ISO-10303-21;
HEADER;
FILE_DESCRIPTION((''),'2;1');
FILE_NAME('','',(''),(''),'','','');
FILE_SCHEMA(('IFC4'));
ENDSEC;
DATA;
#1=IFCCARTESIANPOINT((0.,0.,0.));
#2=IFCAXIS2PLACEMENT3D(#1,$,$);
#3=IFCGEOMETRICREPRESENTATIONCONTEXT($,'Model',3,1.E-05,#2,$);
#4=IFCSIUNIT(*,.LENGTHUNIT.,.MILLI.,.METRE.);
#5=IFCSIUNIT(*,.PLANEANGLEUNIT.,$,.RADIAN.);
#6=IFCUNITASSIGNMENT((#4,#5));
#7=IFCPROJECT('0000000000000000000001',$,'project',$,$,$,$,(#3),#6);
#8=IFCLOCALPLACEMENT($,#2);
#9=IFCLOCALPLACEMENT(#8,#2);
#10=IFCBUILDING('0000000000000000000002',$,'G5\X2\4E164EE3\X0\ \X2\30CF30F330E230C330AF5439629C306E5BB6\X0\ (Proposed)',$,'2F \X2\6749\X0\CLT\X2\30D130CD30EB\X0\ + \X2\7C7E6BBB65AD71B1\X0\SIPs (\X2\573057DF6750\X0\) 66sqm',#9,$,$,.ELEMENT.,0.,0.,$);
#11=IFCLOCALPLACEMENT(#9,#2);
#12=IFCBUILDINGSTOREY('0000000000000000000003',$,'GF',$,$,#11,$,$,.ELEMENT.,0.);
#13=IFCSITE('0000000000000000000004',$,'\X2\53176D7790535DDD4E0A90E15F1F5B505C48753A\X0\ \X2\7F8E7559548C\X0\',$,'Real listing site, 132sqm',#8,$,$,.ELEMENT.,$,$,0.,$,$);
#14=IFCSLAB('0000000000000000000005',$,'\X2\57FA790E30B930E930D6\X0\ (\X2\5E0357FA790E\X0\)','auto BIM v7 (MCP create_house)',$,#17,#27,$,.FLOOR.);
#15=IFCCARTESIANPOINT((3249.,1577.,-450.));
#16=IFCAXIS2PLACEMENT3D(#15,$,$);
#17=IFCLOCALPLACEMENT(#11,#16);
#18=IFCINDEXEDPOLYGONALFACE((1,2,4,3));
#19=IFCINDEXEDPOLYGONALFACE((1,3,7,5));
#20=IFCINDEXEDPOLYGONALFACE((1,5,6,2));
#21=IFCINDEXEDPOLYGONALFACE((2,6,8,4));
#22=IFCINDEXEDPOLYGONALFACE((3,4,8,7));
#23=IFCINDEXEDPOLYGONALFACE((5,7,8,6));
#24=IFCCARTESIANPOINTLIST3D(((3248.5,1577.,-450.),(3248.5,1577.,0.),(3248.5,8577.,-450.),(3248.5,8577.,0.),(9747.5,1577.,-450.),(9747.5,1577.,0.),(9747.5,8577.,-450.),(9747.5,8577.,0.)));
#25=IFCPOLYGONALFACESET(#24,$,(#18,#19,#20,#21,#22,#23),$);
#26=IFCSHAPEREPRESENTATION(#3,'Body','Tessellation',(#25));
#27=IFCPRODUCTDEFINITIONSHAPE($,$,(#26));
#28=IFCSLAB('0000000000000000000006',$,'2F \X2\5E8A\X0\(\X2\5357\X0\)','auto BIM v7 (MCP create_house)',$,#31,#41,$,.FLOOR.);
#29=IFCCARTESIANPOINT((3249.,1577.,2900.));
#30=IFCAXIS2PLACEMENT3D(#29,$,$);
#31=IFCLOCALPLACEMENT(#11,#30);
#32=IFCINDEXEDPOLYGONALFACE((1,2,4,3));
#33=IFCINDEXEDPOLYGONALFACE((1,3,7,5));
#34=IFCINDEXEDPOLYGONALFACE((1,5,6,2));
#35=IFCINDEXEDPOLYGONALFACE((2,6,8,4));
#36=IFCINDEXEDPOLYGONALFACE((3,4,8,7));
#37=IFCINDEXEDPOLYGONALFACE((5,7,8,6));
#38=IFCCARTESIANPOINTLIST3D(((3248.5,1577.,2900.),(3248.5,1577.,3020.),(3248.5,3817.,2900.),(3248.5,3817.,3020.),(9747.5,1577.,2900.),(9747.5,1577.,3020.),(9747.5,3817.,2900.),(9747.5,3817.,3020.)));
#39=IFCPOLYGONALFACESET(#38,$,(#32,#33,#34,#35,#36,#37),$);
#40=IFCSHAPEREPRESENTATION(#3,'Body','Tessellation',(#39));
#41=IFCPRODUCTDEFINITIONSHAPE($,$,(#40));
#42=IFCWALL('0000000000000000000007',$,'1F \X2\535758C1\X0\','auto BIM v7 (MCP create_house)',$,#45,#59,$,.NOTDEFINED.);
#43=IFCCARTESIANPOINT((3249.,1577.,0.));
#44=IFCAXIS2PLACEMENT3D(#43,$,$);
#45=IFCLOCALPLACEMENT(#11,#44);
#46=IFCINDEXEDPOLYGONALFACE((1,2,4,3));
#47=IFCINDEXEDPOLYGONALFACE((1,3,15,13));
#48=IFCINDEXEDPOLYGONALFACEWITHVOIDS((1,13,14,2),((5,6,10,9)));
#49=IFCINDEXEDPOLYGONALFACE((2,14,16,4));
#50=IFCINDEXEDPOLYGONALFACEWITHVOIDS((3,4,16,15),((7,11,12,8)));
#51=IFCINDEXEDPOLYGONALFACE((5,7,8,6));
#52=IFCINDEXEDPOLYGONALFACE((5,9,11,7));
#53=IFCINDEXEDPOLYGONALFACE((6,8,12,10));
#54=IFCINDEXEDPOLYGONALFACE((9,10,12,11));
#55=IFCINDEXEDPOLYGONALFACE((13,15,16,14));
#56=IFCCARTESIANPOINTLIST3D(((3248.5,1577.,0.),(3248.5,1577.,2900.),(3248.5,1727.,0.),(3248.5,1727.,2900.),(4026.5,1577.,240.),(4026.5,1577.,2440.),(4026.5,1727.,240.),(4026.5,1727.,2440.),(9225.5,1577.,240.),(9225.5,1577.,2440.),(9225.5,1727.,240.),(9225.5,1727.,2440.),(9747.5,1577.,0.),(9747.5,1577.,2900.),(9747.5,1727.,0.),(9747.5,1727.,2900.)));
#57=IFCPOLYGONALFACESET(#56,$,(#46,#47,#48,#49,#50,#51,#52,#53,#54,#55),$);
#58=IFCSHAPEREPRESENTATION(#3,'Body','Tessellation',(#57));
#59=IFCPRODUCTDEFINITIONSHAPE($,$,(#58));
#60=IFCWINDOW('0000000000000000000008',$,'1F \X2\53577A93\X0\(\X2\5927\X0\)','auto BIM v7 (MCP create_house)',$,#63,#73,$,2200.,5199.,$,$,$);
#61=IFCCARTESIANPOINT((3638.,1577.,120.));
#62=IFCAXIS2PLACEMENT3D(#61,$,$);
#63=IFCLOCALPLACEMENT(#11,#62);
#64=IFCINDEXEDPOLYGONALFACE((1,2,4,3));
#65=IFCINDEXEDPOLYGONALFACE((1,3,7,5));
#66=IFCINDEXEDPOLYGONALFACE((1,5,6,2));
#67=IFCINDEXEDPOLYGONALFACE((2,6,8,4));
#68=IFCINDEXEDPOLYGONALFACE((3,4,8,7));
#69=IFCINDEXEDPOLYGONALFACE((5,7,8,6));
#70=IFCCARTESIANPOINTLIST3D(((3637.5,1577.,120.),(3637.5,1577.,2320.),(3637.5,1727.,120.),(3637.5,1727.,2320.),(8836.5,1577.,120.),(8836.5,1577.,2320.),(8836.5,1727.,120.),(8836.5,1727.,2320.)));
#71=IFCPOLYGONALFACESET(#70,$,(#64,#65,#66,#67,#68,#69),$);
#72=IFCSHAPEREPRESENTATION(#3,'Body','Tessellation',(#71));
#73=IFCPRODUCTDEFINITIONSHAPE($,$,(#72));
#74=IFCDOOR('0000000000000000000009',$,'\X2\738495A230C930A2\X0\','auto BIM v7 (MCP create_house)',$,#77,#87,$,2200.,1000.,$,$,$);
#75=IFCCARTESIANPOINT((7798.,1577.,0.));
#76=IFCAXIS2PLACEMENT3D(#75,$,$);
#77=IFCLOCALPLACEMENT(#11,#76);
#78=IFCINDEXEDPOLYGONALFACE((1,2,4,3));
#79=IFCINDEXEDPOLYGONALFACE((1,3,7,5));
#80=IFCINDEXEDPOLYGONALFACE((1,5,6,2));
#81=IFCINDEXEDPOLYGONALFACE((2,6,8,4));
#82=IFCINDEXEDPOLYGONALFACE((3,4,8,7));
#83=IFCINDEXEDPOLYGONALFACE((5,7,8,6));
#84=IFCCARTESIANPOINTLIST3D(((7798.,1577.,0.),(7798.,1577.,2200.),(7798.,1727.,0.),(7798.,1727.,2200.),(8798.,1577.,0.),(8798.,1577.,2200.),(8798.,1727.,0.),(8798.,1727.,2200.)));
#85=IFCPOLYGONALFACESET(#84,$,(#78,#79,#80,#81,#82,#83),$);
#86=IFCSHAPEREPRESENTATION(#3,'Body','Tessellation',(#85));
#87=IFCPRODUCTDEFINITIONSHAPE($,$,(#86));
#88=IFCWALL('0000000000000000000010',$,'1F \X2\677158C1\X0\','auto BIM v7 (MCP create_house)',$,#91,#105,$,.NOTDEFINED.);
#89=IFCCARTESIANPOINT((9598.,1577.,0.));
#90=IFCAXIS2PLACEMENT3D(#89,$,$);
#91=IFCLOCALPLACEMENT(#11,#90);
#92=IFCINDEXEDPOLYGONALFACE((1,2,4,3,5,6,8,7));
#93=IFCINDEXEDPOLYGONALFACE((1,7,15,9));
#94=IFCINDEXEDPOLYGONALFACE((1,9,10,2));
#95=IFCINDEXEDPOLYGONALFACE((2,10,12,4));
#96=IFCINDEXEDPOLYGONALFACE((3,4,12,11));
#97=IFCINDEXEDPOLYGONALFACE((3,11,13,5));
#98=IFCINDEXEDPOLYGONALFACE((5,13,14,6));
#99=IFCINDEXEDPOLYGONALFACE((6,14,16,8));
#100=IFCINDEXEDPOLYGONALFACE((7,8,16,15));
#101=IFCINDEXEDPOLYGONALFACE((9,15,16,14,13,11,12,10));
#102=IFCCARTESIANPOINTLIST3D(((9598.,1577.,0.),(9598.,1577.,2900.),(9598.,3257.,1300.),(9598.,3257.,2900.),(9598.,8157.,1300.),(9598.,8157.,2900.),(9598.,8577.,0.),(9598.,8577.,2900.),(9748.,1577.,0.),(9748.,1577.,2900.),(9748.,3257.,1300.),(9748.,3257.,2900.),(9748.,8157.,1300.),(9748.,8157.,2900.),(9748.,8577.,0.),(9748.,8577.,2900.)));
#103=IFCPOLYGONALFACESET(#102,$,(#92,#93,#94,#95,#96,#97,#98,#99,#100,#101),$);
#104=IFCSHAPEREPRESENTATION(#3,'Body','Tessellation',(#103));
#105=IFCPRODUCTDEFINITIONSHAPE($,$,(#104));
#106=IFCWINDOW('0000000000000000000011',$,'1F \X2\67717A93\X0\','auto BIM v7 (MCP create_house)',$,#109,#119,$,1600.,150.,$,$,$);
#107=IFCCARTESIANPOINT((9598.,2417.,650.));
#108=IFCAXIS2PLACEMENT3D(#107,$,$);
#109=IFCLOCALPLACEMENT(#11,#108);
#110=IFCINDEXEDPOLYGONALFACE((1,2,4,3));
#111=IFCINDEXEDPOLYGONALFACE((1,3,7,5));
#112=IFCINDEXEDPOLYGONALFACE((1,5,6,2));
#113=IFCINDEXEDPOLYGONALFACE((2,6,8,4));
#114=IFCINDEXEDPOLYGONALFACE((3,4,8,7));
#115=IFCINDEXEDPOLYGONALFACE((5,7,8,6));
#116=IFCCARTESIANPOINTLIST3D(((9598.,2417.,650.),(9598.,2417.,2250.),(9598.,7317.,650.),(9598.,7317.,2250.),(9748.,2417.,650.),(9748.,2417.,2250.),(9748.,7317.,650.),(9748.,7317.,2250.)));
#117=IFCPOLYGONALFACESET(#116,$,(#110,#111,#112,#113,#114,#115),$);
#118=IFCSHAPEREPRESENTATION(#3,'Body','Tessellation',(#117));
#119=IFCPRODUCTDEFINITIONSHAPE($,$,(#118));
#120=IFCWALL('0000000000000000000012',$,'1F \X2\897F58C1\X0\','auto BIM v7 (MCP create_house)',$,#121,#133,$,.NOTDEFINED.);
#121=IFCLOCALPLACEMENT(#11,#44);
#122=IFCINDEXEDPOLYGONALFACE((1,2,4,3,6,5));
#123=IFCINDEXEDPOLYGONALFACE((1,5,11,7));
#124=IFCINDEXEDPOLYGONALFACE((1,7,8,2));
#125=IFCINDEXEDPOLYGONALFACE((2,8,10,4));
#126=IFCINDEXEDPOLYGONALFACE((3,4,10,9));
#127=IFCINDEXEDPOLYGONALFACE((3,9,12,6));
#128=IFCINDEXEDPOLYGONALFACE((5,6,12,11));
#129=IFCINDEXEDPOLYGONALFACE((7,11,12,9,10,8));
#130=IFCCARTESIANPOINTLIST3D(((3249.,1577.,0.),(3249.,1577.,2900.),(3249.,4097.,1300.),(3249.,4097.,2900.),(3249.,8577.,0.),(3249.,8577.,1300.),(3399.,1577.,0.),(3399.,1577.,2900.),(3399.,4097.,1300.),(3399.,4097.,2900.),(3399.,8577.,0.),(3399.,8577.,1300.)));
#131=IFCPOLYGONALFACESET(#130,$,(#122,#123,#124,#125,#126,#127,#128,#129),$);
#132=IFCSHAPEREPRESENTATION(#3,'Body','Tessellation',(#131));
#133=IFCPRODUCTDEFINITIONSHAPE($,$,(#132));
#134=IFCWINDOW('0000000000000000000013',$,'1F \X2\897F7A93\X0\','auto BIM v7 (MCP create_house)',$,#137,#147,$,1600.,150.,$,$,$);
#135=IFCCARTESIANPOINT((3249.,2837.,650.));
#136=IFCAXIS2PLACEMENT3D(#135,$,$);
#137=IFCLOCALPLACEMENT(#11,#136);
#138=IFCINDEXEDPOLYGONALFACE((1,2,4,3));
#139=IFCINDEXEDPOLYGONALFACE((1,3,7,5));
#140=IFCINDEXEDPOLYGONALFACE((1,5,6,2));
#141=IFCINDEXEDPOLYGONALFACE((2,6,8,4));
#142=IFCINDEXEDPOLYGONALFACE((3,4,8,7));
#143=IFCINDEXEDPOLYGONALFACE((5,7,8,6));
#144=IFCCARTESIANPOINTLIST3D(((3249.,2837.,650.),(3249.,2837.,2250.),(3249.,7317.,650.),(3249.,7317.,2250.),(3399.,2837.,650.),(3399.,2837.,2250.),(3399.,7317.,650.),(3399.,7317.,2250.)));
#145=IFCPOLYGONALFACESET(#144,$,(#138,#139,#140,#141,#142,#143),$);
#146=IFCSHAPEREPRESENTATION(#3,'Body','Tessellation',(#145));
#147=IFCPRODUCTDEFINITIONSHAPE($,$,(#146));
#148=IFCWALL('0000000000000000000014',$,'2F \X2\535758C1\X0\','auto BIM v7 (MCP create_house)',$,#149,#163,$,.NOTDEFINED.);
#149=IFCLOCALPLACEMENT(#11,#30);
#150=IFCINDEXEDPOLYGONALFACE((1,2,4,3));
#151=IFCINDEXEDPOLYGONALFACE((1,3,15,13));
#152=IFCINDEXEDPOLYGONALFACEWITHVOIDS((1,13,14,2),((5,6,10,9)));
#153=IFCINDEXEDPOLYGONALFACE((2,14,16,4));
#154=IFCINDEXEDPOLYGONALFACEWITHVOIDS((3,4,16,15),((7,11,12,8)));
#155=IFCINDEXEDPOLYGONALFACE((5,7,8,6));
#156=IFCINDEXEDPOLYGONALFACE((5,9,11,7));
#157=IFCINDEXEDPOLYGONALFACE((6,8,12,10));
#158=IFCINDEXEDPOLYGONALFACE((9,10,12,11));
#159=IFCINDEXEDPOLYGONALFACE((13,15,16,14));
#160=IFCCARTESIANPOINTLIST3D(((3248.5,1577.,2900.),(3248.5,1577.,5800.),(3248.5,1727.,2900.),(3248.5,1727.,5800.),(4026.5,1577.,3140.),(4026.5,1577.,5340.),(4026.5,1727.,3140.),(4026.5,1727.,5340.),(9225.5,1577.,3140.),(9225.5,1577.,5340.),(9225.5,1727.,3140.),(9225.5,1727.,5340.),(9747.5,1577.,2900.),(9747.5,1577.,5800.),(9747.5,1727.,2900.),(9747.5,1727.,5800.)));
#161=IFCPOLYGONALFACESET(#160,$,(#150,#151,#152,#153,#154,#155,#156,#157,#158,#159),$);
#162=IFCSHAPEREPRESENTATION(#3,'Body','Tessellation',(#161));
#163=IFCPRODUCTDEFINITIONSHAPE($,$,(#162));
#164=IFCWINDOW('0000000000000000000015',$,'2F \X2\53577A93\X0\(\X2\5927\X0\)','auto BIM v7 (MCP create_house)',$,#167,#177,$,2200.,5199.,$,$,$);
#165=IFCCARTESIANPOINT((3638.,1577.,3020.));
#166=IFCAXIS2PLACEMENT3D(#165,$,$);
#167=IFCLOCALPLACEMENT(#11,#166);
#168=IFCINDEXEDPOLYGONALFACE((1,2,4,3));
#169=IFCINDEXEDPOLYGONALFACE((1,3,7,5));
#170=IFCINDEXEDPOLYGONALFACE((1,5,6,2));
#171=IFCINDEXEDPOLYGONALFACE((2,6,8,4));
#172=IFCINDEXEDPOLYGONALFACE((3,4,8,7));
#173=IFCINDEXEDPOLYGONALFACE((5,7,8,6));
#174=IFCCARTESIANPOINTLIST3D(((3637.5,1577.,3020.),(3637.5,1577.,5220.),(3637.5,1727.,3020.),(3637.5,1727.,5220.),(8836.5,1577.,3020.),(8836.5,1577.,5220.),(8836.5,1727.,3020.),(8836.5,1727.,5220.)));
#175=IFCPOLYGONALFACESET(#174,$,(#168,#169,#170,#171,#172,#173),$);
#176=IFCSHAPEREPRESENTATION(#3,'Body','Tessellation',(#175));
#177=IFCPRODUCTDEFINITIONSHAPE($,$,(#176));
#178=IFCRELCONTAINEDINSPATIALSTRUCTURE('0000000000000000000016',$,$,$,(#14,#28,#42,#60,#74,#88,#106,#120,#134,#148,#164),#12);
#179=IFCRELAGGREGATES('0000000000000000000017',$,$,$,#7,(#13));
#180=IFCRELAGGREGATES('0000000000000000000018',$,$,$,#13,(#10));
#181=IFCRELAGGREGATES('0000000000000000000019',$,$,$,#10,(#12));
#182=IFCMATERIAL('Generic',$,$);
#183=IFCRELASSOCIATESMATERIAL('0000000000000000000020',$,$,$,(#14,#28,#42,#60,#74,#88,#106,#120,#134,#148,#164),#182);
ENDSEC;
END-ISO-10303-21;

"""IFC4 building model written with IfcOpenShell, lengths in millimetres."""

from ifc_helpers import new_model, si_unit, frame, frame_2d, origin, place, context, project, spatial, rectangle, extrude, material, element, fill, save


model = new_model("IFC4")

# Units and contexts
model_context = context("Model", 3, precision=1e-05, world=origin())
ifc_project = project(units=[si_unit("LENGTHUNIT", "METRE", prefix="MILLI"), si_unit("PLANEANGLEUNIT", "RADIAN")], contexts=[model_context])

# Site, building, storey
site_placement = place(None, origin())
site = spatial("IfcSite", under=ifc_project, at=site_placement, Name="北海道川上郡弟子屈町 美留和", ObjectType="Real listing site, 132sqm", CompositionType="ELEMENT", RefElevation=0.0)
building_placement = place(site_placement, origin())
building = spatial("IfcBuilding", under=site, at=building_placement, Name="G5世代 ハンモック吹抜の家 (Proposed)", ObjectType="2F 杉CLTパネル + 籾殻断熱SIPs (地域材) 66sqm", CompositionType="ELEMENT", ElevationOfRefHeight=0.0, ElevationOfTerrain=0.0)
storey_placement = place(building_placement, origin())
storey = spatial("IfcBuildingStorey", under=building, at=storey_placement, Name="GF", CompositionType="ELEMENT", Elevation=0.0)

# Slabs
ifc_material = material(Name="Generic")
slab_1_placement = place(storey_placement, frame((3249.0, 1577.0, -450.0)))
element("IfcSlab", 1, at=slab_1_placement, inside=storey, material=ifc_material, Name="基礎スラブ (布基礎)", Description="auto BIM v7 (MCP create_house)", PredefinedType="FLOOR", context=model_context, shape_type="SweptSolid", body=[
    extrude(rectangle(XDim=6499.0, YDim=7000.0, at=frame_2d((3249.0, 3500.0))), frame((3249.0, 1577.0, -450.0)), (0.0, 0.0, 1.0), 450.0),
])
slab_2_placement = place(storey_placement, frame((3249.0, 1577.0, 2900.0)))
element("IfcSlab", 2, at=slab_2_placement, inside=storey, material=ifc_material, Name="2F 床(南)", Description="auto BIM v7 (MCP create_house)", PredefinedType="FLOOR", context=model_context, shape_type="SweptSolid", body=[
    extrude(rectangle(XDim=6499.0, YDim=2240.0, at=frame_2d((3249.0, 1120.0))), frame((3249.0, 1577.0, 2900.0)), (0.0, 0.0, 1.0), 120.0),
])

# Wall, openings, window, door
wall_1_placement = place(storey_placement, frame((3249.0, 1577.0, 0.0)))
wall_1 = element("IfcWall", 3, at=wall_1_placement, inside=storey, material=ifc_material, Name="1F 南壁", Description="auto BIM v7 (MCP create_house)", PredefinedType="NOTDEFINED", context=model_context, shape_type="SweptSolid", body=[
    extrude(rectangle(XDim=6499.0, YDim=150.0, at=frame_2d((3249.0, 75.0))), frame((3249.0, 1577.0, 0.0)), (0.0, 0.0, 1.0), 2900.0),
])
opening_1_placement = place(storey_placement, frame((3638.0, 1577.0, 120.0)))
opening_1 = element("IfcOpeningElement", 4, at=opening_1_placement, cuts=wall_1, PredefinedType="NOTDEFINED", context=model_context, shape_type="SweptSolid", body=[
    extrude(rectangle(XDim=5199.0, YDim=150.0, at=frame_2d((2599.0, 75.0))), frame((3638.0, 1577.0, 120.0)), (0.0, 0.0, 1.0), 2200.0),
])
opening_2_placement = place(storey_placement, frame((7798.0, 1577.0, 0.0)))
opening_2 = element("IfcOpeningElement", 5, at=opening_2_placement, cuts=wall_1, PredefinedType="NOTDEFINED", context=model_context, shape_type="SweptSolid", body=[
    extrude(rectangle(XDim=1000.0, YDim=150.0, at=frame_2d((500.0, 75.0))), frame((7798.0, 1577.0, 0.0)), (0.0, 0.0, 1.0), 2200.0),
])
window_1_placement = place(storey_placement, frame((3638.0, 1577.0, 120.0)))
window_1 = element("IfcWindow", 6, at=window_1_placement, inside=storey, material=ifc_material, Name="1F 南窓(大)", Description="auto BIM v7 (MCP create_house)", OverallHeight=2200.0, OverallWidth=5199.0, context=model_context, shape_type="SweptSolid", body=[
    extrude(rectangle(XDim=5199.0, YDim=150.0, at=frame_2d((2599.0, 75.0))), frame((3638.0, 1577.0, 120.0)), (0.0, 0.0, 1.0), 2200.0),
])
fill(opening_1, window_1)
door_placement = place(storey_placement, frame((7798.0, 1577.0, 0.0)))
door = element("IfcDoor", 7, at=door_placement, inside=storey, material=ifc_material, Name="玄関ドア", Description="auto BIM v7 (MCP create_house)", OverallHeight=2200.0, OverallWidth=1000.0, context=model_context, shape_type="SweptSolid", body=[
    extrude(rectangle(XDim=1000.0, YDim=150.0, at=frame_2d((500.0, 75.0))), frame((7798.0, 1577.0, 0.0)), (0.0, 0.0, 1.0), 2200.0),
])
fill(opening_2, door)

# Walls, openings, windows
wall_2_placement = place(storey_placement, frame((9598.0, 1577.0, 0.0)))
wall_2 = element("IfcWall", 8, at=wall_2_placement, inside=storey, material=ifc_material, Name="1F 東壁", Description="auto BIM v7 (MCP create_house)", PredefinedType="NOTDEFINED", context=model_context, shape_type="SweptSolid", body=[
    extrude(rectangle(XDim=150.0, YDim=7000.0, at=frame_2d((75.0, 3500.0))), frame((9598.0, 1577.0, 0.0)), (0.0, 0.0, 1.0), 2900.0),
])
opening_3_placement = place(storey_placement, frame((9598.0, 2417.0, 650.0)))
opening_3 = element("IfcOpeningElement", 9, at=opening_3_placement, cuts=wall_2, PredefinedType="NOTDEFINED", context=model_context, shape_type="SweptSolid", body=[
    extrude(rectangle(XDim=150.0, YDim=4900.0, at=frame_2d((75.0, 2450.0))), frame((9598.0, 2417.0, 650.0)), (0.0, 0.0, 1.0), 1600.0),
])
window_2_placement = place(storey_placement, frame((9598.0, 2417.0, 650.0)))
window_2 = element("IfcWindow", 10, at=window_2_placement, inside=storey, material=ifc_material, Name="1F 東窓", Description="auto BIM v7 (MCP create_house)", OverallHeight=1600.0, OverallWidth=150.0, context=model_context, shape_type="SweptSolid", body=[
    extrude(rectangle(XDim=150.0, YDim=4900.0, at=frame_2d((75.0, 2450.0))), frame((9598.0, 2417.0, 650.0)), (0.0, 0.0, 1.0), 1600.0),
])
fill(opening_3, window_2)
wall_3_placement = place(storey_placement, frame((3249.0, 1577.0, 0.0)))
wall_3 = element("IfcWall", 11, at=wall_3_placement, inside=storey, material=ifc_material, Name="1F 西壁", Description="auto BIM v7 (MCP create_house)", PredefinedType="NOTDEFINED", context=model_context, shape_type="SweptSolid", body=[
    extrude(rectangle(XDim=150.0, YDim=7000.0, at=frame_2d((75.0, 3500.0))), frame((3249.0, 1577.0, 0.0)), (0.0, 0.0, 1.0), 2900.0),
])
opening_4_placement = place(storey_placement, frame((3249.0, 2837.0, 650.0)))
opening_4 = element("IfcOpeningElement", 12, at=opening_4_placement, cuts=wall_3, PredefinedType="NOTDEFINED", context=model_context, shape_type="SweptSolid", body=[
    extrude(rectangle(XDim=150.0, YDim=4480.0, at=frame_2d((75.0, 2240.0))), frame((3249.0, 2837.0, 650.0)), (0.0, 0.0, 1.0), 1600.0),
])
window_3_placement = place(storey_placement, frame((3249.0, 2837.0, 650.0)))
window_3 = element("IfcWindow", 13, at=window_3_placement, inside=storey, material=ifc_material, Name="1F 西窓", Description="auto BIM v7 (MCP create_house)", OverallHeight=1600.0, OverallWidth=150.0, context=model_context, shape_type="SweptSolid", body=[
    extrude(rectangle(XDim=150.0, YDim=4480.0, at=frame_2d((75.0, 2240.0))), frame((3249.0, 2837.0, 650.0)), (0.0, 0.0, 1.0), 1600.0),
])
fill(opening_4, window_3)

# Wall, opening, window
wall_4_placement = place(storey_placement, frame((3249.0, 1577.0, 2900.0)))
wall_4 = element("IfcWall", 14, at=wall_4_placement, inside=storey, material=ifc_material, Name="2F 南壁", Description="auto BIM v7 (MCP create_house)", PredefinedType="NOTDEFINED", context=model_context, shape_type="SweptSolid", body=[
    extrude(rectangle(XDim=6499.0, YDim=150.0, at=frame_2d((3249.0, 75.0))), frame((3249.0, 1577.0, 2900.0)), (0.0, 0.0, 1.0), 2900.0),
])
opening_5_placement = place(storey_placement, frame((3638.0, 1577.0, 3020.0)))
opening_5 = element("IfcOpeningElement", 15, at=opening_5_placement, cuts=wall_4, PredefinedType="NOTDEFINED", context=model_context, shape_type="SweptSolid", body=[
    extrude(rectangle(XDim=5199.0, YDim=150.0, at=frame_2d((2599.0, 75.0))), frame((3638.0, 1577.0, 3020.0)), (0.0, 0.0, 1.0), 2200.0),
])
window_4_placement = place(storey_placement, frame((3638.0, 1577.0, 3020.0)))
window_4 = element("IfcWindow", 16, at=window_4_placement, inside=storey, material=ifc_material, Name="2F 南窓(大)", Description="auto BIM v7 (MCP create_house)", OverallHeight=2200.0, OverallWidth=5199.0, context=model_context, shape_type="SweptSolid", body=[
    extrude(rectangle(XDim=5199.0, YDim=150.0, at=frame_2d((2599.0, 75.0))), frame((3638.0, 1577.0, 3020.0)), (0.0, 0.0, 1.0), 2200.0),
])
fill(opening_5, window_4)

save(model, "model.ifc")
